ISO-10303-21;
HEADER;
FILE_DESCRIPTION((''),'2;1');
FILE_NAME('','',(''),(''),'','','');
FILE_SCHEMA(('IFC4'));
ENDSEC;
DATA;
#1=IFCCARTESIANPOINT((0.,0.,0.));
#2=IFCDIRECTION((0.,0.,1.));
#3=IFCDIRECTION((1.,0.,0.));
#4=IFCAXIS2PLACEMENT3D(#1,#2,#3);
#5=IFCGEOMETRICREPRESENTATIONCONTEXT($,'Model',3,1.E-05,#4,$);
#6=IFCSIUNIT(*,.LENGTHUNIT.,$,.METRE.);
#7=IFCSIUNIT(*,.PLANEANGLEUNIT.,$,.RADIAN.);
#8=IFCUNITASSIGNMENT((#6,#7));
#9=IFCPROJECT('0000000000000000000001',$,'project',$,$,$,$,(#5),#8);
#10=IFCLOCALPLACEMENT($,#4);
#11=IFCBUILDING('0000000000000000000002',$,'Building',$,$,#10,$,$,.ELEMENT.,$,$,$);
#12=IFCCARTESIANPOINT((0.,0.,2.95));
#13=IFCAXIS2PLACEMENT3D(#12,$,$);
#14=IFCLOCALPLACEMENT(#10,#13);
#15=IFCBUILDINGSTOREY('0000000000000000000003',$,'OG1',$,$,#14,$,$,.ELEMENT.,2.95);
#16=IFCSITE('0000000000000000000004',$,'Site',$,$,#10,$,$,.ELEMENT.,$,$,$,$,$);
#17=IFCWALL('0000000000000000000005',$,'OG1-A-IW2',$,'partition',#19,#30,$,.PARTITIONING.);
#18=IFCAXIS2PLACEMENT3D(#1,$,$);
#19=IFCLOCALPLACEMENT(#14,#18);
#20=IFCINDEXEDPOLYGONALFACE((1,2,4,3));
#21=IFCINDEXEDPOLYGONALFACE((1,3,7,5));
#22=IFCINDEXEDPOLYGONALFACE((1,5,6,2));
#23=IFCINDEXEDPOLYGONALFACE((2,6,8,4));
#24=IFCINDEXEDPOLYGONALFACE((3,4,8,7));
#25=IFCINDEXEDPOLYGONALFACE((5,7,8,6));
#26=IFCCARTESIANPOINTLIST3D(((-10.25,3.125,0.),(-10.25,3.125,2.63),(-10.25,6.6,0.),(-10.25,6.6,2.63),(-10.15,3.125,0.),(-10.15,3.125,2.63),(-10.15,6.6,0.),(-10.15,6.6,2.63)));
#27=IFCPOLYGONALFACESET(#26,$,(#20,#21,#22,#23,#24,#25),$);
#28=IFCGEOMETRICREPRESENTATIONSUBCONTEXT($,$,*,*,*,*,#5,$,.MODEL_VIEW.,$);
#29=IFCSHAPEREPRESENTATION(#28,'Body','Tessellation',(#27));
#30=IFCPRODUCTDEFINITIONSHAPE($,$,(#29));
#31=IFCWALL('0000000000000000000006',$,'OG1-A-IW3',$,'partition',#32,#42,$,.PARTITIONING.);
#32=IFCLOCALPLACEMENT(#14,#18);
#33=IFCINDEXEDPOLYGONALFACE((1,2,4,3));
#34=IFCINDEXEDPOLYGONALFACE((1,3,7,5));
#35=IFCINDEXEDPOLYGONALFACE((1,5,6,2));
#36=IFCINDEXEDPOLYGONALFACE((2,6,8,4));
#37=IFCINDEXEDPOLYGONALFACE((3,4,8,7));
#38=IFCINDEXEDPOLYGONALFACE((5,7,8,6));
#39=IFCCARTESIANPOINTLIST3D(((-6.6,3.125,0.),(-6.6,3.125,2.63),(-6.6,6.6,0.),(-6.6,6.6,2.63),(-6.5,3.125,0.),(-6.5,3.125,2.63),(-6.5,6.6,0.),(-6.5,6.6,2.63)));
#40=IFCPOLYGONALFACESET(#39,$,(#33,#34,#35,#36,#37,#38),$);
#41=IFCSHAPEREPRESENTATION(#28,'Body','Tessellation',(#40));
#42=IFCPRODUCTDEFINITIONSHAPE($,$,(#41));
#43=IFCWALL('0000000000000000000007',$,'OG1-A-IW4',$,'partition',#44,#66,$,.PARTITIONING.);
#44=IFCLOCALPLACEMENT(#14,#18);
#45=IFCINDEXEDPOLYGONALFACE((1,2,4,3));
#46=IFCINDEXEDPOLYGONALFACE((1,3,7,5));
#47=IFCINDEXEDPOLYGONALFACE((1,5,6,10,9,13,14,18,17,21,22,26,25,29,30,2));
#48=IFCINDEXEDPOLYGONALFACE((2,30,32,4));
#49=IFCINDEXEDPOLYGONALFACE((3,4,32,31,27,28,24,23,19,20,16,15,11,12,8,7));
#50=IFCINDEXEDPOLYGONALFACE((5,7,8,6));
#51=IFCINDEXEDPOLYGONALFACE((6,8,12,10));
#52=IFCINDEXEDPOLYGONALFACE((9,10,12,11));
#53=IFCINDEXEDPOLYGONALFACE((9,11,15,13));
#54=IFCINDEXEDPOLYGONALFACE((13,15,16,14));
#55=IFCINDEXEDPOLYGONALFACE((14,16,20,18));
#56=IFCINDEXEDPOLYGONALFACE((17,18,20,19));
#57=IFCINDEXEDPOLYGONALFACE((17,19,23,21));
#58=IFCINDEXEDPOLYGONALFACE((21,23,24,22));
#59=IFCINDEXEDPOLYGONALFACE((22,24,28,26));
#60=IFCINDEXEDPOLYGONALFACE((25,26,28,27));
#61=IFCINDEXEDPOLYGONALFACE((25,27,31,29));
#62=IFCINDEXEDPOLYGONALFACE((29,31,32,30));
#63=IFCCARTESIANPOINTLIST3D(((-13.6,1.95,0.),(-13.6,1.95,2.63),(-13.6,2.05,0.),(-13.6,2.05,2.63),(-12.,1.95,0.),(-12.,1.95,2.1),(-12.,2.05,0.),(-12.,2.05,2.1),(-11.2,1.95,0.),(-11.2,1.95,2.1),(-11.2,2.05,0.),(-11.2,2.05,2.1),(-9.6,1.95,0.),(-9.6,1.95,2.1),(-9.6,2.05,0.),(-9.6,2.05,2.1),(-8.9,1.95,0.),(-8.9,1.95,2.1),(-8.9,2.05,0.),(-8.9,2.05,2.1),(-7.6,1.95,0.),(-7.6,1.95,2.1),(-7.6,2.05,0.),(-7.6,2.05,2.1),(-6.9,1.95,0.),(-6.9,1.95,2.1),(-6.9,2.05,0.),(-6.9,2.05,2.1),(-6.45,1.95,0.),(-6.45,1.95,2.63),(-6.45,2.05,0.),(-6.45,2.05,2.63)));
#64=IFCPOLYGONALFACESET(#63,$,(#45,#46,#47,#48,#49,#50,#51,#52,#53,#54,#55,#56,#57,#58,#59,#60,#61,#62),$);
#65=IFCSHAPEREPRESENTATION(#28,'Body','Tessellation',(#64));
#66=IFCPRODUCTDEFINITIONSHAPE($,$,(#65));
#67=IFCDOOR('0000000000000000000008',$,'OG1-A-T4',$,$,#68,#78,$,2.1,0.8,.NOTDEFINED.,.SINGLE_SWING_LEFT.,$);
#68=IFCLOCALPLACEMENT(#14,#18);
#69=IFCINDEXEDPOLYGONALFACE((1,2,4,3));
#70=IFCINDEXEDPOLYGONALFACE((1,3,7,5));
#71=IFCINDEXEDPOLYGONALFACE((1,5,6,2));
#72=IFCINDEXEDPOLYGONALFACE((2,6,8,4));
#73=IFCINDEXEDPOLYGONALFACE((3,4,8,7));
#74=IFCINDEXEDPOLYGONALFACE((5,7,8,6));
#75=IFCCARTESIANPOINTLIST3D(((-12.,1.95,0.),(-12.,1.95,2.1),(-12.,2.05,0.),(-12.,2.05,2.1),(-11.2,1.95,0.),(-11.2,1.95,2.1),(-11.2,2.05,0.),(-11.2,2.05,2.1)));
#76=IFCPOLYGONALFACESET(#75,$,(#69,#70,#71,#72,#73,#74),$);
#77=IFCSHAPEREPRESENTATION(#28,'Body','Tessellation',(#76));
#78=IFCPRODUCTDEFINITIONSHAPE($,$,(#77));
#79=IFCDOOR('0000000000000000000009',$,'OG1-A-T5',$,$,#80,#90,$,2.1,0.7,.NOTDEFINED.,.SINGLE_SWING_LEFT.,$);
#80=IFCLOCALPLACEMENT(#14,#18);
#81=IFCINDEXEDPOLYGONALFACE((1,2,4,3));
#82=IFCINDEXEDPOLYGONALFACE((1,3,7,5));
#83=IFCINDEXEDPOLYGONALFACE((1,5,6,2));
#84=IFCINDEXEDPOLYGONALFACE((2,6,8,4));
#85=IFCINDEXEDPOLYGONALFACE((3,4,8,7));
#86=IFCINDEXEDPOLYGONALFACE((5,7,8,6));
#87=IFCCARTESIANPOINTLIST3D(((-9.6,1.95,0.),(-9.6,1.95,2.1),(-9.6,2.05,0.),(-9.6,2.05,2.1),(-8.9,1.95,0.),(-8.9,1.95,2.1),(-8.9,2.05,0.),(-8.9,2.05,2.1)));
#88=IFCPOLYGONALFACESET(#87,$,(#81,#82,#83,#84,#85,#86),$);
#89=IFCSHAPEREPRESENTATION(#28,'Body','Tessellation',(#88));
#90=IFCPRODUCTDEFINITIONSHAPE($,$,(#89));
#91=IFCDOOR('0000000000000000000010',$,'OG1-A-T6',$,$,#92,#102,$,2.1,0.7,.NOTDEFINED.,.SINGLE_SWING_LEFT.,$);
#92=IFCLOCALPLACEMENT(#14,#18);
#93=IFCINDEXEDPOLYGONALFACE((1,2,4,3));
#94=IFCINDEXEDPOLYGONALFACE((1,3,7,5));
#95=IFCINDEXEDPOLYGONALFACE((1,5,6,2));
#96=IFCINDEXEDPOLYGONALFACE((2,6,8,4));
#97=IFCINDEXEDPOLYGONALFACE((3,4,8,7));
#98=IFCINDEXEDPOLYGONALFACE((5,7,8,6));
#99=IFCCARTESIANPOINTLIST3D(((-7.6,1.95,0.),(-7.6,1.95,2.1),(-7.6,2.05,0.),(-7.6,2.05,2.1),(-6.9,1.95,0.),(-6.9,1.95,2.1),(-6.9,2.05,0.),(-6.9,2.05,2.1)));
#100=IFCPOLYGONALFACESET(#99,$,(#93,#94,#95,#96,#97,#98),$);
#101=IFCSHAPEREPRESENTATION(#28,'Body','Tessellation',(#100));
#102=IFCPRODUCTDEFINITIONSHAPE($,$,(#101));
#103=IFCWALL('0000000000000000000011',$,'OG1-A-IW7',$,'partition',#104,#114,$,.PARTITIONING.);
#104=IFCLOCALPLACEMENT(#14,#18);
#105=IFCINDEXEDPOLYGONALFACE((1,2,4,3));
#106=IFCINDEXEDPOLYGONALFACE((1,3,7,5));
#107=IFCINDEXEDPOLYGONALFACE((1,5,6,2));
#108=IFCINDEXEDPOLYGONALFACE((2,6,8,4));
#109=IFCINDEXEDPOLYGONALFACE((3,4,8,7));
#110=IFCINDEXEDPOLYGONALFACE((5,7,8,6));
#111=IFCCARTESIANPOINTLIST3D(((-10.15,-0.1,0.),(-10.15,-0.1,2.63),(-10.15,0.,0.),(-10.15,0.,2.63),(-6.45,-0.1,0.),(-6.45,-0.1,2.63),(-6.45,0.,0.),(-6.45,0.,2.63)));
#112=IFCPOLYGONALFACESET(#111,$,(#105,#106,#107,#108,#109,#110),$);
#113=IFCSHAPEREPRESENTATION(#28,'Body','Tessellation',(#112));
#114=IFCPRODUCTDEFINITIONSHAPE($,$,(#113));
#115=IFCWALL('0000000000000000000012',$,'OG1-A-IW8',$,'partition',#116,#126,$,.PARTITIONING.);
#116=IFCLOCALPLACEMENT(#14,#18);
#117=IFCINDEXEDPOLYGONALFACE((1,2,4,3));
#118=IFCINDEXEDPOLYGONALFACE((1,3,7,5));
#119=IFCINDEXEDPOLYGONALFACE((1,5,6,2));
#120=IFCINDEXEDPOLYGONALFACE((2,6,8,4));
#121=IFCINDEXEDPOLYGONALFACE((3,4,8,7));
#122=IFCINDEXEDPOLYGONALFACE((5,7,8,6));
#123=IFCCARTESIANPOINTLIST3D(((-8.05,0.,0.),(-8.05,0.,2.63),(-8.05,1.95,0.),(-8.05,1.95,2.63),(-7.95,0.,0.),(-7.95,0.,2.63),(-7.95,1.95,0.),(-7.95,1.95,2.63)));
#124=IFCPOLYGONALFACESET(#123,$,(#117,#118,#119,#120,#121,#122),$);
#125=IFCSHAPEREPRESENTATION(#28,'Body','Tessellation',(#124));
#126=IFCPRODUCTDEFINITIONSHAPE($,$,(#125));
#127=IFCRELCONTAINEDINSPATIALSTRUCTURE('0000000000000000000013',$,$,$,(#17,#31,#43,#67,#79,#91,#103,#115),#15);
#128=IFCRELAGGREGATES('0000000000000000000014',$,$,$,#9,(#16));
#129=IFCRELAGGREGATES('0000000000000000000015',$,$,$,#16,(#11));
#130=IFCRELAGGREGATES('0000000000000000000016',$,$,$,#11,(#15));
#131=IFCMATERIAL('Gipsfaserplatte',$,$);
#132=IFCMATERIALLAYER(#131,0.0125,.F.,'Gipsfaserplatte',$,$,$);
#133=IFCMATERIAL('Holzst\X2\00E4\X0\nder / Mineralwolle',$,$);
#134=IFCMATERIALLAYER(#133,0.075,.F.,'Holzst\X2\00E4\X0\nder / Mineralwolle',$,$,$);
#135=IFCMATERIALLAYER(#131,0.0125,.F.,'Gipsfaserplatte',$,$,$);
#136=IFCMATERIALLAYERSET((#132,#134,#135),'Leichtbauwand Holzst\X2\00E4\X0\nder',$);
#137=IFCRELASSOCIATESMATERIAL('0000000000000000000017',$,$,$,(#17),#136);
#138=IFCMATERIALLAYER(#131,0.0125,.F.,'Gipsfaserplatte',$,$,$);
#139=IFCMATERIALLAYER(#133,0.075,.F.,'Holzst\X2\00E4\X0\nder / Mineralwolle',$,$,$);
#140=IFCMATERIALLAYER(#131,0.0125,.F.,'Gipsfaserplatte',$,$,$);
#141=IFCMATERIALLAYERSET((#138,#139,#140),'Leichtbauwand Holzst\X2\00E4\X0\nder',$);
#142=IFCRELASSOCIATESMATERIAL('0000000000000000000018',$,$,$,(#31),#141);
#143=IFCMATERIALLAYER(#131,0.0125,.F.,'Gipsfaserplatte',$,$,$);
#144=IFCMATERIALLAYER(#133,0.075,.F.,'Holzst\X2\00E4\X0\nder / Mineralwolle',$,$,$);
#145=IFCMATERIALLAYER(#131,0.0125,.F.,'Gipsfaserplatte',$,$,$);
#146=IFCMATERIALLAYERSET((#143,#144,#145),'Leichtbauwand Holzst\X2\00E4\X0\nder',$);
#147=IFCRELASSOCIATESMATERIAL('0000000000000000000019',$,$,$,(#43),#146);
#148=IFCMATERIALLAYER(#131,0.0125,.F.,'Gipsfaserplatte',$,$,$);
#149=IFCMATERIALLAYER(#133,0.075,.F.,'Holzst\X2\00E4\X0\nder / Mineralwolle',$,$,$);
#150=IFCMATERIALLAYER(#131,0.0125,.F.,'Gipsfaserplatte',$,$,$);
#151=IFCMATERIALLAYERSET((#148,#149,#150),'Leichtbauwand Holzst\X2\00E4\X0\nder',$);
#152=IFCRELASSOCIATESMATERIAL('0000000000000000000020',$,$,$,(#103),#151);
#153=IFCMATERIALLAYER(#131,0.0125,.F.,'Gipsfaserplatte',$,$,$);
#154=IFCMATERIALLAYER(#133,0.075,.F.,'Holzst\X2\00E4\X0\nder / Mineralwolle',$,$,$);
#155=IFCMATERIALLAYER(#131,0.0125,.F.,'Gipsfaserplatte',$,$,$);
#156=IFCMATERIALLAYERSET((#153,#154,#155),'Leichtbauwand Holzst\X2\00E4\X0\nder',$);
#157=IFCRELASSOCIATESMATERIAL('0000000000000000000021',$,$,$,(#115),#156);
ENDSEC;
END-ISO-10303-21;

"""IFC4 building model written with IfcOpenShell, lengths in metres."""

from ifc_helpers import new_model, si_unit, frame, frame_2d, origin, origin_with_axes, place, context, subcontext, project, spatial, rectangle, extrude, material, layer, layer_set, element, fill, save


model = new_model("IFC4")

# Units and contexts
model_context = context("Model", 3, precision=1e-05, world=origin_with_axes())
sub_context = subcontext(model_context, None, None, "MODEL_VIEW")
ifc_project = project(units=[si_unit("LENGTHUNIT", "METRE"), si_unit("PLANEANGLEUNIT", "RADIAN")], contexts=[model_context])

# Site, building, storey
placement = place(None, origin_with_axes())
site = spatial("IfcSite", under=ifc_project, at=placement, Name="Site", CompositionType="ELEMENT")
building = spatial("IfcBuilding", under=site, at=placement, Name="Building", CompositionType="ELEMENT")
storey_placement = place(placement, frame((0.0, 0.0, 2.95)))
storey = spatial("IfcBuildingStorey", under=building, at=storey_placement, Name="OG1", CompositionType="ELEMENT", Elevation=2.95)

# Shared definitions
ifc_material_1 = material(Name="Gipsfaserplatte")

# Walls
ifc_layer_1 = layer(ifc_material_1, 0.0125, ventilated=False, Name="Gipsfaserplatte")
ifc_material_2 = material(Name="Holzständer / Mineralwolle")
ifc_layer_2 = layer(ifc_material_2, 0.075, ventilated=False, Name="Holzständer / Mineralwolle")
ifc_layer_3 = layer(ifc_material_1, 0.0125, ventilated=False, Name="Gipsfaserplatte")
ifc_layer_set_1 = layer_set([ifc_layer_1, ifc_layer_2, ifc_layer_3], Name="Leichtbauwand Holzständer")
wall_1_placement = place(storey_placement, frame((-10.2, 3.125, 0.0), z_axis=(0.0, 0.0, 1.0), x_axis=(0.0, 1.0, 0.0)))
element("IfcWall", 1, at=wall_1_placement, inside=storey, material=ifc_layer_set_1, Name="OG1-A-IW2", ObjectType="partition", PredefinedType="PARTITIONING", context=sub_context, shape_type="SweptSolid", body=[
    extrude(rectangle(XDim=3.475, YDim=0.1, at=frame_2d((1.7375, 0.0))), origin(), (0.0, 0.0, 1.0), 2.63),
])
ifc_layer_4 = layer(ifc_material_1, 0.0125, ventilated=False, Name="Gipsfaserplatte")
ifc_layer_5 = layer(ifc_material_2, 0.075, ventilated=False, Name="Holzständer / Mineralwolle")
ifc_layer_6 = layer(ifc_material_1, 0.0125, ventilated=False, Name="Gipsfaserplatte")
ifc_layer_set_2 = layer_set([ifc_layer_4, ifc_layer_5, ifc_layer_6], Name="Leichtbauwand Holzständer")
wall_2_placement = place(storey_placement, frame((-6.55, 3.125, 0.0), z_axis=(0.0, 0.0, 1.0), x_axis=(0.0, 1.0, 0.0)))
element("IfcWall", 2, at=wall_2_placement, inside=storey, material=ifc_layer_set_2, Name="OG1-A-IW3", ObjectType="partition", PredefinedType="PARTITIONING", context=sub_context, shape_type="SweptSolid", body=[
    extrude(rectangle(XDim=3.475, YDim=0.1, at=frame_2d((1.7375, 0.0))), origin(), (0.0, 0.0, 1.0), 2.63),
])

# Wall, openings, doors
ifc_layer_7 = layer(ifc_material_1, 0.0125, ventilated=False, Name="Gipsfaserplatte")
ifc_layer_8 = layer(ifc_material_2, 0.075, ventilated=False, Name="Holzständer / Mineralwolle")
ifc_layer_9 = layer(ifc_material_1, 0.0125, ventilated=False, Name="Gipsfaserplatte")
ifc_layer_set_3 = layer_set([ifc_layer_7, ifc_layer_8, ifc_layer_9], Name="Leichtbauwand Holzständer")
wall_3_placement = place(storey_placement, frame((-13.6, 2.0, 0.0), z_axis=(0.0, 0.0, 1.0), x_axis=(1.0, 0.0, 0.0)))
wall_3 = element("IfcWall", 3, at=wall_3_placement, inside=storey, material=ifc_layer_set_3, Name="OG1-A-IW4", ObjectType="partition", PredefinedType="PARTITIONING", context=sub_context, shape_type="SweptSolid", body=[
    extrude(rectangle(XDim=7.15, YDim=0.1, at=frame_2d((3.575, 0.0))), origin(), (0.0, 0.0, 1.0), 2.63),
])
opening_1_placement = place(wall_3_placement, frame((2.0, 0.1, 0.0), z_axis=(0.0, -1.0, 0.0), x_axis=(1.0, 0.0, 0.0)))
opening_1 = element("IfcOpeningElement", 4, at=opening_1_placement, cuts=wall_3, PredefinedType="OPENING", context=sub_context, shape_type="SweptSolid", body=[
    extrude(rectangle(XDim=0.8, YDim=2.1, at=frame_2d((0.0, 1.05))), origin(), (0.0, 0.0, 1.0), 0.2),
])
opening_2_placement = place(wall_3_placement, frame((4.35, 0.1, 0.0), z_axis=(0.0, -1.0, 0.0), x_axis=(1.0, 0.0, 0.0)))
opening_2 = element("IfcOpeningElement", 5, at=opening_2_placement, cuts=wall_3, PredefinedType="OPENING", context=sub_context, shape_type="SweptSolid", body=[
    extrude(rectangle(XDim=0.7, YDim=2.1, at=frame_2d((0.0, 1.05))), origin(), (0.0, 0.0, 1.0), 0.2),
])
opening_3_placement = place(wall_3_placement, frame((6.35, 0.1, 0.0), z_axis=(0.0, -1.0, 0.0), x_axis=(1.0, 0.0, 0.0)))
opening_3 = element("IfcOpeningElement", 6, at=opening_3_placement, cuts=wall_3, PredefinedType="OPENING", context=sub_context, shape_type="SweptSolid", body=[
    extrude(rectangle(XDim=0.7, YDim=2.1, at=frame_2d((0.0, 1.05))), origin(), (0.0, 0.0, 1.0), 0.2),
])
door_1_placement = place(wall_3_placement, frame((2.0, 0.05, 0.0), z_axis=(0.0, -1.0, 0.0), x_axis=(1.0, 0.0, 0.0)))
door_1 = element("IfcDoor", 7, at=door_1_placement, inside=storey, Name="OG1-A-T4", OperationType="SINGLE_SWING_LEFT", OverallHeight=2.1, OverallWidth=0.8, PredefinedType="NOTDEFINED", context=sub_context, shape_type="SweptSolid", body=[
    extrude(rectangle(XDim=0.8, YDim=2.1, at=frame_2d((0.0, 1.05))), origin(), (0.0, 0.0, 1.0), 0.1),
])
fill(opening_1, door_1)
door_2_placement = place(wall_3_placement, frame((4.35, 0.05, 0.0), z_axis=(0.0, -1.0, 0.0), x_axis=(1.0, 0.0, 0.0)))
door_2 = element("IfcDoor", 8, at=door_2_placement, inside=storey, Name="OG1-A-T5", OperationType="SINGLE_SWING_LEFT", OverallHeight=2.1, OverallWidth=0.7, PredefinedType="NOTDEFINED", context=sub_context, shape_type="SweptSolid", body=[
    extrude(rectangle(XDim=0.7, YDim=2.1, at=frame_2d((0.0, 1.05))), origin(), (0.0, 0.0, 1.0), 0.1),
])
fill(opening_2, door_2)
door_3_placement = place(wall_3_placement, frame((6.35, 0.05, 0.0), z_axis=(0.0, -1.0, 0.0), x_axis=(1.0, 0.0, 0.0)))
door_3 = element("IfcDoor", 9, at=door_3_placement, inside=storey, Name="OG1-A-T6", OperationType="SINGLE_SWING_LEFT", OverallHeight=2.1, OverallWidth=0.7, PredefinedType="NOTDEFINED", context=sub_context, shape_type="SweptSolid", body=[
    extrude(rectangle(XDim=0.7, YDim=2.1, at=frame_2d((0.0, 1.05))), origin(), (0.0, 0.0, 1.0), 0.1),
])
fill(opening_3, door_3)

# Walls
ifc_layer_10 = layer(ifc_material_1, 0.0125, ventilated=False, Name="Gipsfaserplatte")
ifc_layer_11 = layer(ifc_material_2, 0.075, ventilated=False, Name="Holzständer / Mineralwolle")
ifc_layer_12 = layer(ifc_material_1, 0.0125, ventilated=False, Name="Gipsfaserplatte")
ifc_layer_set_4 = layer_set([ifc_layer_10, ifc_layer_11, ifc_layer_12], Name="Leichtbauwand Holzständer")
wall_4_placement = place(storey_placement, frame((-10.15, -0.05, 0.0), z_axis=(0.0, 0.0, 1.0), x_axis=(1.0, 0.0, 0.0)))
element("IfcWall", 10, at=wall_4_placement, inside=storey, material=ifc_layer_set_4, Name="OG1-A-IW7", ObjectType="partition", PredefinedType="PARTITIONING", context=sub_context, shape_type="SweptSolid", body=[
    extrude(rectangle(XDim=3.7, YDim=0.1, at=frame_2d((1.85, 0.0))), origin(), (0.0, 0.0, 1.0), 2.63),
])
ifc_layer_13 = layer(ifc_material_1, 0.0125, ventilated=False, Name="Gipsfaserplatte")
ifc_layer_14 = layer(ifc_material_2, 0.075, ventilated=False, Name="Holzständer / Mineralwolle")
ifc_layer_15 = layer(ifc_material_1, 0.0125, ventilated=False, Name="Gipsfaserplatte")
ifc_layer_set_5 = layer_set([ifc_layer_13, ifc_layer_14, ifc_layer_15], Name="Leichtbauwand Holzständer")
wall_5_placement = place(storey_placement, frame((-8.0, 0.0, 0.0), z_axis=(0.0, 0.0, 1.0), x_axis=(0.0, 1.0, 0.0)))
element("IfcWall", 11, at=wall_5_placement, inside=storey, material=ifc_layer_set_5, Name="OG1-A-IW8", ObjectType="partition", PredefinedType="PARTITIONING", context=sub_context, shape_type="SweptSolid", body=[
    extrude(rectangle(XDim=1.95, YDim=0.1, at=frame_2d((0.975, 0.0))), origin(), (0.0, 0.0, 1.0), 2.63),
])

save(model, "model.ifc")
